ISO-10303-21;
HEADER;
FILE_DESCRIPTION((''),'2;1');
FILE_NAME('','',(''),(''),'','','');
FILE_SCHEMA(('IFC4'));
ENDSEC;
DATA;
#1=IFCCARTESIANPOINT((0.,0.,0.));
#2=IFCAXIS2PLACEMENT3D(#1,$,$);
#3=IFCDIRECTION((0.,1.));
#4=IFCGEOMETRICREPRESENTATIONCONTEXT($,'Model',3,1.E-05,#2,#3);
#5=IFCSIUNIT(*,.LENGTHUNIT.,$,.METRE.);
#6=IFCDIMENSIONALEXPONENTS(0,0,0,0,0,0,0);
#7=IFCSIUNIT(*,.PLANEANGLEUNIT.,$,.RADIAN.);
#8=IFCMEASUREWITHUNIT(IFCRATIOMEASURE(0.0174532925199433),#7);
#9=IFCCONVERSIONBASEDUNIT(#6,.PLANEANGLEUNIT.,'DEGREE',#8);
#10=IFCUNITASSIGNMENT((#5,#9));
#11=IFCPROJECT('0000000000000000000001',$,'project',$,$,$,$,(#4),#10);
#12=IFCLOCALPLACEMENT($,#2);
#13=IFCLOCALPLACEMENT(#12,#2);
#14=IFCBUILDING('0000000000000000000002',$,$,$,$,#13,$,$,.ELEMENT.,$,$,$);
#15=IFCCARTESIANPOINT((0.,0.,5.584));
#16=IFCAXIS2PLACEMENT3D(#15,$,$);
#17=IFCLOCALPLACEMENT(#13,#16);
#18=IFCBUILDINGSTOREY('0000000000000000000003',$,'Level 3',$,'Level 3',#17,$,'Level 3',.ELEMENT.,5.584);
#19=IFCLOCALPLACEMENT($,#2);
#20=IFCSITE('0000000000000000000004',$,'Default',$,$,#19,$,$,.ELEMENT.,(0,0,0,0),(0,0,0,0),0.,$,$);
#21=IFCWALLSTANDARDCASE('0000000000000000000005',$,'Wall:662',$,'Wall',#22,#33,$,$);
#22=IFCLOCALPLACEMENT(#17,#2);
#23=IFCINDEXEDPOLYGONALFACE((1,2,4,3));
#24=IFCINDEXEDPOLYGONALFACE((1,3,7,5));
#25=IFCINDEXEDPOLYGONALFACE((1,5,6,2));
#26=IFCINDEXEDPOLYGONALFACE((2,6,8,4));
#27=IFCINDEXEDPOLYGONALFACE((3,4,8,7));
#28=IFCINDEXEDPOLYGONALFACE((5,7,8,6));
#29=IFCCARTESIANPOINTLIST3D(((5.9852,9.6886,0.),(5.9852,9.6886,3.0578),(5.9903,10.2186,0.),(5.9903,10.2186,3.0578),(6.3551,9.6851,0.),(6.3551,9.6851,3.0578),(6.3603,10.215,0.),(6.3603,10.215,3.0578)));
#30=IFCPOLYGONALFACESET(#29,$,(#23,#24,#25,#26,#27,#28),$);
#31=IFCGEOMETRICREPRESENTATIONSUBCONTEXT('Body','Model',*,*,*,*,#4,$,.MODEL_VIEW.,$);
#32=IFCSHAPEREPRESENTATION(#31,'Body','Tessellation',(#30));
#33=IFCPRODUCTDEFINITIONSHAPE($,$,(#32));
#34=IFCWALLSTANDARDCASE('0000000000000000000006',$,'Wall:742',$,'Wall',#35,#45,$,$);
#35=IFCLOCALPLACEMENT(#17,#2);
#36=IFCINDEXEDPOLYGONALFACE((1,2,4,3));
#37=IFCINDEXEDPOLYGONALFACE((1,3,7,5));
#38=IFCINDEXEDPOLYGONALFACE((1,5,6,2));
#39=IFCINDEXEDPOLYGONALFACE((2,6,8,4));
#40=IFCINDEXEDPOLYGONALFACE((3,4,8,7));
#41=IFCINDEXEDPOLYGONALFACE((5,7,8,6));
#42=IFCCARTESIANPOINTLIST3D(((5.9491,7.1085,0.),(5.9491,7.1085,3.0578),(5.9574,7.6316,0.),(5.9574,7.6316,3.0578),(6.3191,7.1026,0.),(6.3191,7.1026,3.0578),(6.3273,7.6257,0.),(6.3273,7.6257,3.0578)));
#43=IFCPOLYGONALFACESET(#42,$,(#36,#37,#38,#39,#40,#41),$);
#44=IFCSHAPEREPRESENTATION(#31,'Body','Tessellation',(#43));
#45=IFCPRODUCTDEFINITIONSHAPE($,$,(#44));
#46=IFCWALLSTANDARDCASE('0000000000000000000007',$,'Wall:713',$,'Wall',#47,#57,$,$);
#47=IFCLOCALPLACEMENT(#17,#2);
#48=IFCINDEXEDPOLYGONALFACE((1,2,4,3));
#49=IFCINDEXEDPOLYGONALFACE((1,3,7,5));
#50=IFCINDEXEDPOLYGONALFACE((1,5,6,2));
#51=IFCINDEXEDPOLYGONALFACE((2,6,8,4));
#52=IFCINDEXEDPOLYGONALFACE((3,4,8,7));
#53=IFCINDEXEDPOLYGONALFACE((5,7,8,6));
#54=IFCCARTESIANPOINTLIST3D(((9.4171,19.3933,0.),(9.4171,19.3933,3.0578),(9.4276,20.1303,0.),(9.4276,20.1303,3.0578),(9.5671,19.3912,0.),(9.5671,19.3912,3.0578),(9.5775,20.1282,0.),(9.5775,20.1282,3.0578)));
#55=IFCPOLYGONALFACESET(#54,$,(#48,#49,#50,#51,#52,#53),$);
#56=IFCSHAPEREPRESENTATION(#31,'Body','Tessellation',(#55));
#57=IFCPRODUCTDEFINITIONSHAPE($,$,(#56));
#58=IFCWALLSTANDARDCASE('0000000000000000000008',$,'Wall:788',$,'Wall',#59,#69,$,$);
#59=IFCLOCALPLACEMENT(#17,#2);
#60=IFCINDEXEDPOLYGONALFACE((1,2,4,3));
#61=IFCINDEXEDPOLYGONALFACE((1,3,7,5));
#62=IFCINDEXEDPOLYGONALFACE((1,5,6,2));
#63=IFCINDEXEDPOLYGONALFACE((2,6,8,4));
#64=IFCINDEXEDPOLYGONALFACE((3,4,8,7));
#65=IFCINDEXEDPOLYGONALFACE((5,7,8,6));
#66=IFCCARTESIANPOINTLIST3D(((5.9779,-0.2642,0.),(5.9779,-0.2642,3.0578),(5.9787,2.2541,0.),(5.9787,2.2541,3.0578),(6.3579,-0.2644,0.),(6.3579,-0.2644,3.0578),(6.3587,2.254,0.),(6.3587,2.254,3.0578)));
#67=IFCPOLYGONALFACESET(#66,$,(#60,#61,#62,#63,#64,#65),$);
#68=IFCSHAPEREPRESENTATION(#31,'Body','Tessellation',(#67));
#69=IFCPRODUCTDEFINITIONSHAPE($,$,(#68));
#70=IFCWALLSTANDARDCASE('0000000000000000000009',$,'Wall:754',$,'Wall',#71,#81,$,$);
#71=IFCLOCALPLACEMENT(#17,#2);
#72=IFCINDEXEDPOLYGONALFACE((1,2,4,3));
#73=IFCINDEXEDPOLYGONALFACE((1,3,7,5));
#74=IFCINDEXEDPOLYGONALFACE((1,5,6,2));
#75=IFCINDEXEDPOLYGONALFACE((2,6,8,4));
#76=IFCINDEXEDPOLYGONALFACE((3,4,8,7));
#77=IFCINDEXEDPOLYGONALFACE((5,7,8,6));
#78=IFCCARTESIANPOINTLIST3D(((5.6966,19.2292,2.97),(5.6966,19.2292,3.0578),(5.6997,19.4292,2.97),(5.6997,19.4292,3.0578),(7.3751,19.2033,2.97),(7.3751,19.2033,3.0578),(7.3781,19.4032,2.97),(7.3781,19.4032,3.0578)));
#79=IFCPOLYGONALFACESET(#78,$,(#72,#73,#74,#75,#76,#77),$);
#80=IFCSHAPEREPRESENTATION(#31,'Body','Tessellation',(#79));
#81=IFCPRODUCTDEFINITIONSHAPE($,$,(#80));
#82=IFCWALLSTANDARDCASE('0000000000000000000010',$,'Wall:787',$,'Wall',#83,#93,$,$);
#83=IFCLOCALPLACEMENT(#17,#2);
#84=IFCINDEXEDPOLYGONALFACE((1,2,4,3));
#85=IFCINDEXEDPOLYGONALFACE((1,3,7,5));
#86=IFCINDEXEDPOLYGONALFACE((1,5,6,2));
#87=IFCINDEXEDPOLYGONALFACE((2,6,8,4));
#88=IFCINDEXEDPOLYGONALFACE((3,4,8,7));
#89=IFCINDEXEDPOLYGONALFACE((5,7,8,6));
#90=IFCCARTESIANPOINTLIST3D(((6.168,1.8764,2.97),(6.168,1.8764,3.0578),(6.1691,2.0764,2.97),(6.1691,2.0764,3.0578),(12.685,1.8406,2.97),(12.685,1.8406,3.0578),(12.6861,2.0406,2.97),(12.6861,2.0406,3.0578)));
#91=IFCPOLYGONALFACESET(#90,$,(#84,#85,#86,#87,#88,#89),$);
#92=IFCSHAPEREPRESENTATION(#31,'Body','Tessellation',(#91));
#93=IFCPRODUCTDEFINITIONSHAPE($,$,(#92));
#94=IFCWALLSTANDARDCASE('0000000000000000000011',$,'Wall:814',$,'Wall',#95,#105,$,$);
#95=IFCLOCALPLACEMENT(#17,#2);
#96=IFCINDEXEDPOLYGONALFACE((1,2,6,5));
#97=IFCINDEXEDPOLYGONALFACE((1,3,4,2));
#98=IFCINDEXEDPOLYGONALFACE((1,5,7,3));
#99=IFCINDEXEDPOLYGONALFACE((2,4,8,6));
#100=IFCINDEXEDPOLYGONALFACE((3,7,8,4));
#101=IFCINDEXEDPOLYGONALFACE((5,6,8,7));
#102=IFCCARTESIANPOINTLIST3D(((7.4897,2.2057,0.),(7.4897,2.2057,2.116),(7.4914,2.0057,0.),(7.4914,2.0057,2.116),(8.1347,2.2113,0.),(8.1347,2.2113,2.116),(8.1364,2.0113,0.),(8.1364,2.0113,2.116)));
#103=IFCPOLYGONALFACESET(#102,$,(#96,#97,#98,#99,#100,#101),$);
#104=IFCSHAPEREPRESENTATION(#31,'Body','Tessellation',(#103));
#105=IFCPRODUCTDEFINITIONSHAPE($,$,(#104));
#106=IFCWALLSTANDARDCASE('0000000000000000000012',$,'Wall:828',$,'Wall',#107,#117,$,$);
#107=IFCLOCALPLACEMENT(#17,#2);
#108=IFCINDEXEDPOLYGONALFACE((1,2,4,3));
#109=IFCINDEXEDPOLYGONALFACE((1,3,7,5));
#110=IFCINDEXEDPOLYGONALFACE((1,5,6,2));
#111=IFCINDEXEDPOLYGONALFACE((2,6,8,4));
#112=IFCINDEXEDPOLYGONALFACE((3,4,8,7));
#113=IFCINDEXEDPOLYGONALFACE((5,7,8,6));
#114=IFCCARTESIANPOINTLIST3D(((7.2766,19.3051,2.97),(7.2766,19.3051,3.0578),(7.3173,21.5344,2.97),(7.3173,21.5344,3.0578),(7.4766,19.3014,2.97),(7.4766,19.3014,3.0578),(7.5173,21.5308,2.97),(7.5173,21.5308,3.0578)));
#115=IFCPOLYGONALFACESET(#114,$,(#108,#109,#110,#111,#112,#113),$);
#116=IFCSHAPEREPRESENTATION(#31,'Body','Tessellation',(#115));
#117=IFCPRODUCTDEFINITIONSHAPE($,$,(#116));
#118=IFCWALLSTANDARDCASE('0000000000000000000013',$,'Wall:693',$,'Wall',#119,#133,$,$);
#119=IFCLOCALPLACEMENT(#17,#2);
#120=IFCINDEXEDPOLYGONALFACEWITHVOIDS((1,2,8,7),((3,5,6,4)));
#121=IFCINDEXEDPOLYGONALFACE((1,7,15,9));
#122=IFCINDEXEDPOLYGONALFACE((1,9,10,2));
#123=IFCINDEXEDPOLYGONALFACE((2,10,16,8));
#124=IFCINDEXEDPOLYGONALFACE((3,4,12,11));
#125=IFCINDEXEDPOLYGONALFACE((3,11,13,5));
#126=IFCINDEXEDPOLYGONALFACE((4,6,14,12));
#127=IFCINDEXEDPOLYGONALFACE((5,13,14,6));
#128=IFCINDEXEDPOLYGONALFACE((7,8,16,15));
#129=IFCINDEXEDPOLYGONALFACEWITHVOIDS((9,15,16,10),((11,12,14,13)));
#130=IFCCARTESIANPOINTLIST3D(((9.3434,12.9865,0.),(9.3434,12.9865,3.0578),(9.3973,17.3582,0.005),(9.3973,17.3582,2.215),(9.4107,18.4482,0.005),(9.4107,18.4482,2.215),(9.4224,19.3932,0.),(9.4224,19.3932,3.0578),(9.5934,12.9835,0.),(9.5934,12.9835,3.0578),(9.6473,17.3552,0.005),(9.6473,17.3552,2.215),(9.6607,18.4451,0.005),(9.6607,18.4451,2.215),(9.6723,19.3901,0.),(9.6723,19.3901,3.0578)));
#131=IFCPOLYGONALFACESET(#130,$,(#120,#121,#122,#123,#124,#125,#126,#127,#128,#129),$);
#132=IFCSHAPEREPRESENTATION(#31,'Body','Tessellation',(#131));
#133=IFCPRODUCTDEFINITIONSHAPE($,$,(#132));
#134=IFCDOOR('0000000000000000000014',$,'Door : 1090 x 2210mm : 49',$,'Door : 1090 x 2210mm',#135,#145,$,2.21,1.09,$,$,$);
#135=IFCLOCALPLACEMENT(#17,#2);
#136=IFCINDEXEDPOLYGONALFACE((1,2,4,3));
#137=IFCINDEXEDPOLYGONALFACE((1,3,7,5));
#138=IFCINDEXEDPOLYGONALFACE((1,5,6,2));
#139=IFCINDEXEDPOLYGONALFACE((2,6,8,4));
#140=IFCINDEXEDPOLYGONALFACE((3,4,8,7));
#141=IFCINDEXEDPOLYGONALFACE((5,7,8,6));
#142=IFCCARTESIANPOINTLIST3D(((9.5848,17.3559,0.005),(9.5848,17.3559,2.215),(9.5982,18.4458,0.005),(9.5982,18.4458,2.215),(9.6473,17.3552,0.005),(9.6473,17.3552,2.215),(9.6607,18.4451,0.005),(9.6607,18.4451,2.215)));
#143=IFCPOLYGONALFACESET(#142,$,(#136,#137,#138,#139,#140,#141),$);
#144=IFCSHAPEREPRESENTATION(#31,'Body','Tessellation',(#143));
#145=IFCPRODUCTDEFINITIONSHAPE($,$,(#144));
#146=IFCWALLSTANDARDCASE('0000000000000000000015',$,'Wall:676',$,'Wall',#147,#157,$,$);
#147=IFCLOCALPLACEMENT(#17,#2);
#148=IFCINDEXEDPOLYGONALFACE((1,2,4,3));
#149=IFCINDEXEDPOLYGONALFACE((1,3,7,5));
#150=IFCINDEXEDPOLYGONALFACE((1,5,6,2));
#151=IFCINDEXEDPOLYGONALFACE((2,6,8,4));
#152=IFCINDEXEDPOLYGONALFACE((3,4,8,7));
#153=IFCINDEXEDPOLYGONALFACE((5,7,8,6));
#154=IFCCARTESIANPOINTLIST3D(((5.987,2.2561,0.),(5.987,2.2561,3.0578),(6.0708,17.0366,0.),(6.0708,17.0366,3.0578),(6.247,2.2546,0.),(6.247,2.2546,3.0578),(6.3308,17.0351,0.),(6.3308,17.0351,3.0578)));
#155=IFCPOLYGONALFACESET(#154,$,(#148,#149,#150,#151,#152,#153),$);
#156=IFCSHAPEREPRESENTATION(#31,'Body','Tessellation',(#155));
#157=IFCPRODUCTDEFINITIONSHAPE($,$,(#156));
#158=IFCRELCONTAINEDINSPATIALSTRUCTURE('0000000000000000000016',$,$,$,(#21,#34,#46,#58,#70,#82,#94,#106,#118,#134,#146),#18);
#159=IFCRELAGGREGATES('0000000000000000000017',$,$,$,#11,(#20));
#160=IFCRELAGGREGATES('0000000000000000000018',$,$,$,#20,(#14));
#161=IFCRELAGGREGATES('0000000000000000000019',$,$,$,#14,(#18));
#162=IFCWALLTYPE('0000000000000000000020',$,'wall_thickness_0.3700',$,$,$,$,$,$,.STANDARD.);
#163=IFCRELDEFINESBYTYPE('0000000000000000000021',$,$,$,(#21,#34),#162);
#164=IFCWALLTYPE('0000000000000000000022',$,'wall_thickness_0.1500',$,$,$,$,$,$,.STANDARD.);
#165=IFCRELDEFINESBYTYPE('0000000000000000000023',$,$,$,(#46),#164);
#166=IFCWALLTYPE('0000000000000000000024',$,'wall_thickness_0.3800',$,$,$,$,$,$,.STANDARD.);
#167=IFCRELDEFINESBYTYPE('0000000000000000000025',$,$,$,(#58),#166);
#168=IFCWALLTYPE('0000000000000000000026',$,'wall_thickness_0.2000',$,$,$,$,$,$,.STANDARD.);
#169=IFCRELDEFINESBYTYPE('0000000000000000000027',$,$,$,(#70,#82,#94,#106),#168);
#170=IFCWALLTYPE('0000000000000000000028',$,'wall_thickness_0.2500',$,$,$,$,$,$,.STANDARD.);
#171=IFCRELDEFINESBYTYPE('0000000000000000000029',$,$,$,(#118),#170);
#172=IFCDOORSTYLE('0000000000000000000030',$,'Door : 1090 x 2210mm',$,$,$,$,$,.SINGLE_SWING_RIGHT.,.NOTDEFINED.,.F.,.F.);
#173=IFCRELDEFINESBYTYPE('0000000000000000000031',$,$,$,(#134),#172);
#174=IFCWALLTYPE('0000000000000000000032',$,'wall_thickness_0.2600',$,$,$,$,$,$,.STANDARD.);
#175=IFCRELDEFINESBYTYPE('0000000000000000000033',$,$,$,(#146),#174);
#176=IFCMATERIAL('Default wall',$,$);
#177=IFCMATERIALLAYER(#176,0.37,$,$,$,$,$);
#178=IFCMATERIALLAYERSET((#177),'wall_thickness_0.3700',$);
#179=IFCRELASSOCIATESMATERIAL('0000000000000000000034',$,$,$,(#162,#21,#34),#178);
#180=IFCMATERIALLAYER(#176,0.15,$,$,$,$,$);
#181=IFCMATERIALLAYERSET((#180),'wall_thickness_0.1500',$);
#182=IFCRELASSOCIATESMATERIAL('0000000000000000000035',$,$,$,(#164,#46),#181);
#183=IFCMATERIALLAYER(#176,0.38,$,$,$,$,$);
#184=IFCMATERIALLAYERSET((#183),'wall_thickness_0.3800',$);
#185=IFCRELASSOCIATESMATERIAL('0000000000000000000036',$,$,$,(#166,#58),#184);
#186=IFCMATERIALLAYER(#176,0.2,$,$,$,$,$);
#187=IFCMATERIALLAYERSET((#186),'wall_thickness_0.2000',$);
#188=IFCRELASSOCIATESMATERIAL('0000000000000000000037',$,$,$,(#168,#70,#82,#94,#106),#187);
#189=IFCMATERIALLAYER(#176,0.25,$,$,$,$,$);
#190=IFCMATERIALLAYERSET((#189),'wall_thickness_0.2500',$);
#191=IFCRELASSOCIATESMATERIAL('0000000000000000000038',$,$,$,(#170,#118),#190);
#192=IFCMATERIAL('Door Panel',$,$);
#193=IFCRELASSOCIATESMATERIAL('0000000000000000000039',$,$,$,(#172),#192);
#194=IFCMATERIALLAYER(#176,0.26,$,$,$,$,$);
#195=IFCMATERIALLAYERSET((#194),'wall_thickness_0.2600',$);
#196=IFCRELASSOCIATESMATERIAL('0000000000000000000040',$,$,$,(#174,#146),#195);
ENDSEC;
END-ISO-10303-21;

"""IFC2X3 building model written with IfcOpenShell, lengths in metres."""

from ifc_helpers import new_model, entity, si_unit, converted_unit, direction, frame, frame_2d, origin, origin_2d_with_axis, place, context, subcontext, project, spatial, polyline, rectangle, outline, extrude, source, transform, mapped, material, layer, layer_set, layer_usage, type_object, type_shapes, element, fill, save


model = new_model("IFC2X3")

# Units and contexts
model_context = context("Model", 3, precision=1e-05, world=origin(), true_north=direction((0.0, 1.0)))
body_context = subcontext(model_context, "Body", "Model", "MODEL_VIEW")
ifc_project = project(units=[si_unit("LENGTHUNIT", "METRE"), converted_unit("PLANEANGLEUNIT", "DEGREE", entity("IfcRatioMeasure", 0.0174532925199433), si_unit("PLANEANGLEUNIT", "RADIAN"), dimensions=[0, 0, 0, 0, 0, 0, 0])], contexts=[model_context])

# Site, building, storey
site_placement = place(None, origin())
site = spatial("IfcSite", under=ifc_project, at=site_placement, Name="Default", CompositionType="ELEMENT", RefLatitude=(0, 0, 0, 0), RefLongitude=(0, 0, 0, 0), RefElevation=0.0)
placement_1 = place(None, origin())
building_placement = place(placement_1, origin())
building = spatial("IfcBuilding", under=site, at=building_placement, CompositionType="ELEMENT")
storey_placement = place(building_placement, frame((0.0, 0.0, 5.584)))
storey = spatial("IfcBuildingStorey", under=building, at=storey_placement, Name="Level 3", ObjectType="Level 3", LongName="Level 3", CompositionType="ELEMENT", Elevation=5.584)

# Walls
ifc_material_1 = material(Name="Default wall")
ifc_layer_1 = layer(ifc_material_1, 0.37)
ifc_layer_set_1 = layer_set([ifc_layer_1], Name="wall_thickness_0.3700")
ifc_layer_usage_1 = layer_usage(ifc_layer_set_1, "AXIS2", "POSITIVE", -0.185)
wall_type_1 = type_object("IfcWallType", Name="wall_thickness_0.3700", PredefinedType="STANDARD", material=ifc_layer_set_1)
wall_1_placement = place(storey_placement, frame((6.1753, 10.2168, 0.0), z_axis=(0.0, 0.0, 1.0), x_axis=(-0.009672, -0.999953, 0.0)))
element("IfcWallStandardCase", 1, at=wall_1_placement, inside=storey, type_object=wall_type_1, material=ifc_layer_usage_1, Name="Wall:662", ObjectType="Wall", context=body_context, shape_type="SweptSolid", body=[
    extrude(outline(polyline([(0.53, -0.185), (0.53, 0.185), (0.0, 0.185), (0.0, -0.185), (0.53, -0.185)])), origin(), (0.0, 0.0, 1.0), 3.0578),
])
wall_2_placement = place(storey_placement, frame((6.1424, 7.6286, 0.0), z_axis=(0.0, 0.0, 1.0), x_axis=(-0.015799, -0.999875, 0.0)))
element("IfcWallStandardCase", 2, at=wall_2_placement, inside=storey, type_object=wall_type_1, material=ifc_layer_usage_1, Name="Wall:742", ObjectType="Wall", context=body_context, shape_type="SweptSolid", body=[
    extrude(outline(polyline([(0.5231, -0.185), (0.5231, 0.185), (0.0, 0.185), (0.0, -0.185), (0.5231, -0.185)])), origin(), (0.0, 0.0, 1.0), 3.0578),
])
ifc_layer_2 = layer(ifc_material_1, 0.15)
ifc_layer_set_2 = layer_set([ifc_layer_2], Name="wall_thickness_0.1500")
ifc_layer_usage_2 = layer_usage(ifc_layer_set_2, "AXIS2", "POSITIVE", -0.075)
wall_type_2 = type_object("IfcWallType", Name="wall_thickness_0.1500", PredefinedType="STANDARD", material=ifc_layer_set_2)
wall_3_placement = place(storey_placement, frame((9.5025, 20.1292, 0.0), z_axis=(0.0, 0.0, 1.0), x_axis=(-0.014192, -0.999899, 0.0)))
element("IfcWallStandardCase", 3, at=wall_3_placement, inside=storey, type_object=wall_type_2, material=ifc_layer_usage_2, Name="Wall:713", ObjectType="Wall", context=body_context, shape_type="SweptSolid", body=[
    extrude(outline(polyline([(0.7371, -0.075), (0.7371, 0.075), (0.0, 0.075), (0.0, -0.075), (0.7371, -0.075)])), origin(), (0.0, 0.0, 1.0), 3.0578),
])
ifc_layer_3 = layer(ifc_material_1, 0.38)
ifc_layer_set_3 = layer_set([ifc_layer_3], Name="wall_thickness_0.3800")
ifc_layer_usage_3 = layer_usage(ifc_layer_set_3, "AXIS2", "POSITIVE", -0.19)
wall_type_3 = type_object("IfcWallType", Name="wall_thickness_0.3800", PredefinedType="STANDARD", material=ifc_layer_set_3)
wall_4_placement = place(storey_placement, frame((6.1687, 2.2541, 0.0), z_axis=(0.0, 0.0, 1.0), x_axis=(-0.000287, -1.0, 0.0)))
element("IfcWallStandardCase", 4, at=wall_4_placement, inside=storey, type_object=wall_type_3, material=ifc_layer_usage_3, Name="Wall:788", ObjectType="Wall", context=body_context, shape_type="SweptSolid", body=[
    extrude(outline(polyline([(2.5184, -0.19), (2.5184, 0.19), (0.0, 0.19), (0.0, -0.19), (2.5184, -0.19)])), origin(), (0.0, 0.0, 1.0), 3.0578),
])
ifc_layer_4 = layer(ifc_material_1, 0.2)
ifc_layer_set_4 = layer_set([ifc_layer_4], Name="wall_thickness_0.2000")
ifc_layer_usage_4 = layer_usage(ifc_layer_set_4, "AXIS2", "POSITIVE", -0.1)
wall_type_4 = type_object("IfcWallType", Name="wall_thickness_0.2000", PredefinedType="STANDARD", material=ifc_layer_set_4)
placement_2 = place(building_placement, frame((0.0, 0.0, 8.554)))
wall_5_placement = place(placement_2, frame((5.6981, 19.3292, 0.0), z_axis=(0.0, 0.0, 1.0), x_axis=(0.999881, -0.015454, 0.0)))
element("IfcWallStandardCase", 5, at=wall_5_placement, inside=storey, type_object=wall_type_4, material=ifc_layer_usage_4, Name="Wall:754", ObjectType="Wall", context=body_context, shape_type="SweptSolid", body=[
    extrude(outline(polyline([(1.6787, -0.1), (1.6787, 0.1), (0.0, 0.1), (0.0, -0.1), (1.6787, -0.1)])), origin(), (0.0, 0.0, 1.0), 0.0878),
])
placement_3 = place(building_placement, frame((0.0, 0.0, 8.554)))
wall_6_placement = place(placement_3, frame((6.1686, 1.9764, 0.0), z_axis=(0.0, 0.0, 1.0), x_axis=(0.999985, -0.005495, 0.0)))
element("IfcWallStandardCase", 6, at=wall_6_placement, inside=storey, type_object=wall_type_4, material=ifc_layer_usage_4, Name="Wall:787", ObjectType="Wall", context=body_context, shape_type="SweptSolid", body=[
    extrude(outline(polyline([(6.517, -0.1), (6.517, 0.1), (0.0, 0.1), (0.0, -0.1), (6.517, -0.1)])), origin(), (0.0, 0.0, 1.0), 0.0878),
])
wall_7_placement = place(storey_placement, frame((7.4906, 2.1057, 0.0), z_axis=(0.0, 0.0, 1.0), x_axis=(0.999963, 0.008615, 0.0)))
element("IfcWallStandardCase", 7, at=wall_7_placement, inside=storey, type_object=wall_type_4, material=ifc_layer_usage_4, Name="Wall:814", ObjectType="Wall", context=body_context, shape_type="SweptSolid", body=[
    extrude(outline(polyline([(0.645, -0.1), (0.645, 0.1), (0.0, 0.1), (0.0, -0.1), (0.645, -0.1)])), origin(), (0.0, 0.0, 1.0), 2.116),
])
placement_4 = place(building_placement, frame((0.0, 0.0, 8.554)))
wall_8_placement = place(placement_4, frame((7.4173, 21.5326, 0.0), z_axis=(0.0, 0.0, 1.0), x_axis=(-0.018242, -0.999834, 0.0)))
element("IfcWallStandardCase", 8, at=wall_8_placement, inside=storey, type_object=wall_type_4, material=ifc_layer_usage_4, Name="Wall:828", ObjectType="Wall", context=body_context, shape_type="SweptSolid", body=[
    extrude(outline(polyline([(2.2297, -0.1), (2.2297, 0.1), (0.0, 0.1), (0.0, -0.1), (2.2297, -0.1)])), origin(), (0.0, 0.0, 1.0), 0.0878),
])

# Wall, opening, door
ifc_layer_5 = layer(ifc_material_1, 0.25)
ifc_layer_set_5 = layer_set([ifc_layer_5], Name="wall_thickness_0.2500")
ifc_layer_usage_5 = layer_usage(ifc_layer_set_5, "AXIS2", "POSITIVE", -0.125)
wall_type_5 = type_object("IfcWallType", Name="wall_thickness_0.2500", PredefinedType="STANDARD", material=ifc_layer_set_5)
wall_9_placement = place(storey_placement, frame((9.5474, 19.3917, 0.0), z_axis=(0.0, 0.0, 1.0), x_axis=(-0.01232, -0.999924, 0.0)))
wall_9 = element("IfcWallStandardCase", 9, at=wall_9_placement, inside=storey, type_object=wall_type_5, material=ifc_layer_usage_5, Name="Wall:693", ObjectType="Wall", context=body_context, shape_type="SweptSolid", body=[
    extrude(outline(polyline([(6.4072, -0.125), (6.4072, 0.125), (0.0, 0.125), (0.0, -0.125), (6.4072, -0.125)])), origin(), (0.0, 0.0, 1.0), 3.0578),
])
opening_1_placement = place(wall_9_placement, frame((0.9451, -0.125, 0.005)))
opening_1 = element("IfcOpeningElement", 10, at=opening_1_placement, cuts=wall_9, ObjectType="Opening", context=body_context, shape_type="SweptSolid", body=[
    extrude(rectangle(XDim=1.09, YDim=2.21, at=frame_2d((1.105, 0.545), x_axis=(0.0, 1.0))), frame((0.0, 0.0, 0.0), z_axis=(0.0, 1.0, 0.0), x_axis=(0.0, 0.0, 1.0)), (0.0, 0.0, 1.0), 0.25),
])
ifc_material_2 = material(Name="Door Panel")
door_style = type_object("IfcDoorStyle", Name="Door : 1090 x 2210mm", ConstructionType="NOTDEFINED", OperationType="SINGLE_SWING_RIGHT", ParameterTakesPrecedence=False, Sizeable=False, material=ifc_material_2)
shared_shape_1 = source(origin(), body_context, "Body", "SweptSolid", [
    extrude(rectangle(XDim=0.0625, YDim=1.09, at=origin_2d_with_axis()), frame((0.545, 0.2188, 0.0), z_axis=(0.0, 0.0, 1.0), x_axis=(0.0, 1.0, 0.0)), (0.0, 0.0, 1.0), 2.21),
])
type_shapes(door_style, [shared_shape_1])
door_placement = place(opening_1_placement, origin())
door = element("IfcDoor", 11, at=door_placement, inside=storey, type_object=door_style, Name="Door : 1090 x 2210mm : 49", ObjectType="Door : 1090 x 2210mm", OverallHeight=2.21, OverallWidth=1.09, context=body_context, shape_type="MappedRepresentation", body=[
    mapped(shared_shape_1, transform((0.0, 0.0, 0.0), scale=1.0)),
])
fill(opening_1, door)

# Wall
ifc_layer_6 = layer(ifc_material_1, 0.26)
ifc_layer_set_6 = layer_set([ifc_layer_6], Name="wall_thickness_0.2600")
ifc_layer_usage_6 = layer_usage(ifc_layer_set_6, "AXIS2", "POSITIVE", -0.13)
wall_type_6 = type_object("IfcWallType", Name="wall_thickness_0.2600", PredefinedType="STANDARD", material=ifc_layer_set_6)
wall_10_placement = place(storey_placement, frame((6.2008, 17.0358, 0.0), z_axis=(0.0, 0.0, 1.0), x_axis=(-0.005672, -0.999984, 0.0)))
element("IfcWallStandardCase", 12, at=wall_10_placement, inside=storey, type_object=wall_type_6, material=ifc_layer_usage_6, Name="Wall:676", ObjectType="Wall", context=body_context, shape_type="SweptSolid", body=[
    extrude(outline(polyline([(14.7807, -0.13), (14.7807, 0.13), (0.0, 0.13), (0.0, -0.13), (14.7807, -0.13)])), origin(), (0.0, 0.0, 1.0), 3.0578),
])

save(model, "model.ifc")
